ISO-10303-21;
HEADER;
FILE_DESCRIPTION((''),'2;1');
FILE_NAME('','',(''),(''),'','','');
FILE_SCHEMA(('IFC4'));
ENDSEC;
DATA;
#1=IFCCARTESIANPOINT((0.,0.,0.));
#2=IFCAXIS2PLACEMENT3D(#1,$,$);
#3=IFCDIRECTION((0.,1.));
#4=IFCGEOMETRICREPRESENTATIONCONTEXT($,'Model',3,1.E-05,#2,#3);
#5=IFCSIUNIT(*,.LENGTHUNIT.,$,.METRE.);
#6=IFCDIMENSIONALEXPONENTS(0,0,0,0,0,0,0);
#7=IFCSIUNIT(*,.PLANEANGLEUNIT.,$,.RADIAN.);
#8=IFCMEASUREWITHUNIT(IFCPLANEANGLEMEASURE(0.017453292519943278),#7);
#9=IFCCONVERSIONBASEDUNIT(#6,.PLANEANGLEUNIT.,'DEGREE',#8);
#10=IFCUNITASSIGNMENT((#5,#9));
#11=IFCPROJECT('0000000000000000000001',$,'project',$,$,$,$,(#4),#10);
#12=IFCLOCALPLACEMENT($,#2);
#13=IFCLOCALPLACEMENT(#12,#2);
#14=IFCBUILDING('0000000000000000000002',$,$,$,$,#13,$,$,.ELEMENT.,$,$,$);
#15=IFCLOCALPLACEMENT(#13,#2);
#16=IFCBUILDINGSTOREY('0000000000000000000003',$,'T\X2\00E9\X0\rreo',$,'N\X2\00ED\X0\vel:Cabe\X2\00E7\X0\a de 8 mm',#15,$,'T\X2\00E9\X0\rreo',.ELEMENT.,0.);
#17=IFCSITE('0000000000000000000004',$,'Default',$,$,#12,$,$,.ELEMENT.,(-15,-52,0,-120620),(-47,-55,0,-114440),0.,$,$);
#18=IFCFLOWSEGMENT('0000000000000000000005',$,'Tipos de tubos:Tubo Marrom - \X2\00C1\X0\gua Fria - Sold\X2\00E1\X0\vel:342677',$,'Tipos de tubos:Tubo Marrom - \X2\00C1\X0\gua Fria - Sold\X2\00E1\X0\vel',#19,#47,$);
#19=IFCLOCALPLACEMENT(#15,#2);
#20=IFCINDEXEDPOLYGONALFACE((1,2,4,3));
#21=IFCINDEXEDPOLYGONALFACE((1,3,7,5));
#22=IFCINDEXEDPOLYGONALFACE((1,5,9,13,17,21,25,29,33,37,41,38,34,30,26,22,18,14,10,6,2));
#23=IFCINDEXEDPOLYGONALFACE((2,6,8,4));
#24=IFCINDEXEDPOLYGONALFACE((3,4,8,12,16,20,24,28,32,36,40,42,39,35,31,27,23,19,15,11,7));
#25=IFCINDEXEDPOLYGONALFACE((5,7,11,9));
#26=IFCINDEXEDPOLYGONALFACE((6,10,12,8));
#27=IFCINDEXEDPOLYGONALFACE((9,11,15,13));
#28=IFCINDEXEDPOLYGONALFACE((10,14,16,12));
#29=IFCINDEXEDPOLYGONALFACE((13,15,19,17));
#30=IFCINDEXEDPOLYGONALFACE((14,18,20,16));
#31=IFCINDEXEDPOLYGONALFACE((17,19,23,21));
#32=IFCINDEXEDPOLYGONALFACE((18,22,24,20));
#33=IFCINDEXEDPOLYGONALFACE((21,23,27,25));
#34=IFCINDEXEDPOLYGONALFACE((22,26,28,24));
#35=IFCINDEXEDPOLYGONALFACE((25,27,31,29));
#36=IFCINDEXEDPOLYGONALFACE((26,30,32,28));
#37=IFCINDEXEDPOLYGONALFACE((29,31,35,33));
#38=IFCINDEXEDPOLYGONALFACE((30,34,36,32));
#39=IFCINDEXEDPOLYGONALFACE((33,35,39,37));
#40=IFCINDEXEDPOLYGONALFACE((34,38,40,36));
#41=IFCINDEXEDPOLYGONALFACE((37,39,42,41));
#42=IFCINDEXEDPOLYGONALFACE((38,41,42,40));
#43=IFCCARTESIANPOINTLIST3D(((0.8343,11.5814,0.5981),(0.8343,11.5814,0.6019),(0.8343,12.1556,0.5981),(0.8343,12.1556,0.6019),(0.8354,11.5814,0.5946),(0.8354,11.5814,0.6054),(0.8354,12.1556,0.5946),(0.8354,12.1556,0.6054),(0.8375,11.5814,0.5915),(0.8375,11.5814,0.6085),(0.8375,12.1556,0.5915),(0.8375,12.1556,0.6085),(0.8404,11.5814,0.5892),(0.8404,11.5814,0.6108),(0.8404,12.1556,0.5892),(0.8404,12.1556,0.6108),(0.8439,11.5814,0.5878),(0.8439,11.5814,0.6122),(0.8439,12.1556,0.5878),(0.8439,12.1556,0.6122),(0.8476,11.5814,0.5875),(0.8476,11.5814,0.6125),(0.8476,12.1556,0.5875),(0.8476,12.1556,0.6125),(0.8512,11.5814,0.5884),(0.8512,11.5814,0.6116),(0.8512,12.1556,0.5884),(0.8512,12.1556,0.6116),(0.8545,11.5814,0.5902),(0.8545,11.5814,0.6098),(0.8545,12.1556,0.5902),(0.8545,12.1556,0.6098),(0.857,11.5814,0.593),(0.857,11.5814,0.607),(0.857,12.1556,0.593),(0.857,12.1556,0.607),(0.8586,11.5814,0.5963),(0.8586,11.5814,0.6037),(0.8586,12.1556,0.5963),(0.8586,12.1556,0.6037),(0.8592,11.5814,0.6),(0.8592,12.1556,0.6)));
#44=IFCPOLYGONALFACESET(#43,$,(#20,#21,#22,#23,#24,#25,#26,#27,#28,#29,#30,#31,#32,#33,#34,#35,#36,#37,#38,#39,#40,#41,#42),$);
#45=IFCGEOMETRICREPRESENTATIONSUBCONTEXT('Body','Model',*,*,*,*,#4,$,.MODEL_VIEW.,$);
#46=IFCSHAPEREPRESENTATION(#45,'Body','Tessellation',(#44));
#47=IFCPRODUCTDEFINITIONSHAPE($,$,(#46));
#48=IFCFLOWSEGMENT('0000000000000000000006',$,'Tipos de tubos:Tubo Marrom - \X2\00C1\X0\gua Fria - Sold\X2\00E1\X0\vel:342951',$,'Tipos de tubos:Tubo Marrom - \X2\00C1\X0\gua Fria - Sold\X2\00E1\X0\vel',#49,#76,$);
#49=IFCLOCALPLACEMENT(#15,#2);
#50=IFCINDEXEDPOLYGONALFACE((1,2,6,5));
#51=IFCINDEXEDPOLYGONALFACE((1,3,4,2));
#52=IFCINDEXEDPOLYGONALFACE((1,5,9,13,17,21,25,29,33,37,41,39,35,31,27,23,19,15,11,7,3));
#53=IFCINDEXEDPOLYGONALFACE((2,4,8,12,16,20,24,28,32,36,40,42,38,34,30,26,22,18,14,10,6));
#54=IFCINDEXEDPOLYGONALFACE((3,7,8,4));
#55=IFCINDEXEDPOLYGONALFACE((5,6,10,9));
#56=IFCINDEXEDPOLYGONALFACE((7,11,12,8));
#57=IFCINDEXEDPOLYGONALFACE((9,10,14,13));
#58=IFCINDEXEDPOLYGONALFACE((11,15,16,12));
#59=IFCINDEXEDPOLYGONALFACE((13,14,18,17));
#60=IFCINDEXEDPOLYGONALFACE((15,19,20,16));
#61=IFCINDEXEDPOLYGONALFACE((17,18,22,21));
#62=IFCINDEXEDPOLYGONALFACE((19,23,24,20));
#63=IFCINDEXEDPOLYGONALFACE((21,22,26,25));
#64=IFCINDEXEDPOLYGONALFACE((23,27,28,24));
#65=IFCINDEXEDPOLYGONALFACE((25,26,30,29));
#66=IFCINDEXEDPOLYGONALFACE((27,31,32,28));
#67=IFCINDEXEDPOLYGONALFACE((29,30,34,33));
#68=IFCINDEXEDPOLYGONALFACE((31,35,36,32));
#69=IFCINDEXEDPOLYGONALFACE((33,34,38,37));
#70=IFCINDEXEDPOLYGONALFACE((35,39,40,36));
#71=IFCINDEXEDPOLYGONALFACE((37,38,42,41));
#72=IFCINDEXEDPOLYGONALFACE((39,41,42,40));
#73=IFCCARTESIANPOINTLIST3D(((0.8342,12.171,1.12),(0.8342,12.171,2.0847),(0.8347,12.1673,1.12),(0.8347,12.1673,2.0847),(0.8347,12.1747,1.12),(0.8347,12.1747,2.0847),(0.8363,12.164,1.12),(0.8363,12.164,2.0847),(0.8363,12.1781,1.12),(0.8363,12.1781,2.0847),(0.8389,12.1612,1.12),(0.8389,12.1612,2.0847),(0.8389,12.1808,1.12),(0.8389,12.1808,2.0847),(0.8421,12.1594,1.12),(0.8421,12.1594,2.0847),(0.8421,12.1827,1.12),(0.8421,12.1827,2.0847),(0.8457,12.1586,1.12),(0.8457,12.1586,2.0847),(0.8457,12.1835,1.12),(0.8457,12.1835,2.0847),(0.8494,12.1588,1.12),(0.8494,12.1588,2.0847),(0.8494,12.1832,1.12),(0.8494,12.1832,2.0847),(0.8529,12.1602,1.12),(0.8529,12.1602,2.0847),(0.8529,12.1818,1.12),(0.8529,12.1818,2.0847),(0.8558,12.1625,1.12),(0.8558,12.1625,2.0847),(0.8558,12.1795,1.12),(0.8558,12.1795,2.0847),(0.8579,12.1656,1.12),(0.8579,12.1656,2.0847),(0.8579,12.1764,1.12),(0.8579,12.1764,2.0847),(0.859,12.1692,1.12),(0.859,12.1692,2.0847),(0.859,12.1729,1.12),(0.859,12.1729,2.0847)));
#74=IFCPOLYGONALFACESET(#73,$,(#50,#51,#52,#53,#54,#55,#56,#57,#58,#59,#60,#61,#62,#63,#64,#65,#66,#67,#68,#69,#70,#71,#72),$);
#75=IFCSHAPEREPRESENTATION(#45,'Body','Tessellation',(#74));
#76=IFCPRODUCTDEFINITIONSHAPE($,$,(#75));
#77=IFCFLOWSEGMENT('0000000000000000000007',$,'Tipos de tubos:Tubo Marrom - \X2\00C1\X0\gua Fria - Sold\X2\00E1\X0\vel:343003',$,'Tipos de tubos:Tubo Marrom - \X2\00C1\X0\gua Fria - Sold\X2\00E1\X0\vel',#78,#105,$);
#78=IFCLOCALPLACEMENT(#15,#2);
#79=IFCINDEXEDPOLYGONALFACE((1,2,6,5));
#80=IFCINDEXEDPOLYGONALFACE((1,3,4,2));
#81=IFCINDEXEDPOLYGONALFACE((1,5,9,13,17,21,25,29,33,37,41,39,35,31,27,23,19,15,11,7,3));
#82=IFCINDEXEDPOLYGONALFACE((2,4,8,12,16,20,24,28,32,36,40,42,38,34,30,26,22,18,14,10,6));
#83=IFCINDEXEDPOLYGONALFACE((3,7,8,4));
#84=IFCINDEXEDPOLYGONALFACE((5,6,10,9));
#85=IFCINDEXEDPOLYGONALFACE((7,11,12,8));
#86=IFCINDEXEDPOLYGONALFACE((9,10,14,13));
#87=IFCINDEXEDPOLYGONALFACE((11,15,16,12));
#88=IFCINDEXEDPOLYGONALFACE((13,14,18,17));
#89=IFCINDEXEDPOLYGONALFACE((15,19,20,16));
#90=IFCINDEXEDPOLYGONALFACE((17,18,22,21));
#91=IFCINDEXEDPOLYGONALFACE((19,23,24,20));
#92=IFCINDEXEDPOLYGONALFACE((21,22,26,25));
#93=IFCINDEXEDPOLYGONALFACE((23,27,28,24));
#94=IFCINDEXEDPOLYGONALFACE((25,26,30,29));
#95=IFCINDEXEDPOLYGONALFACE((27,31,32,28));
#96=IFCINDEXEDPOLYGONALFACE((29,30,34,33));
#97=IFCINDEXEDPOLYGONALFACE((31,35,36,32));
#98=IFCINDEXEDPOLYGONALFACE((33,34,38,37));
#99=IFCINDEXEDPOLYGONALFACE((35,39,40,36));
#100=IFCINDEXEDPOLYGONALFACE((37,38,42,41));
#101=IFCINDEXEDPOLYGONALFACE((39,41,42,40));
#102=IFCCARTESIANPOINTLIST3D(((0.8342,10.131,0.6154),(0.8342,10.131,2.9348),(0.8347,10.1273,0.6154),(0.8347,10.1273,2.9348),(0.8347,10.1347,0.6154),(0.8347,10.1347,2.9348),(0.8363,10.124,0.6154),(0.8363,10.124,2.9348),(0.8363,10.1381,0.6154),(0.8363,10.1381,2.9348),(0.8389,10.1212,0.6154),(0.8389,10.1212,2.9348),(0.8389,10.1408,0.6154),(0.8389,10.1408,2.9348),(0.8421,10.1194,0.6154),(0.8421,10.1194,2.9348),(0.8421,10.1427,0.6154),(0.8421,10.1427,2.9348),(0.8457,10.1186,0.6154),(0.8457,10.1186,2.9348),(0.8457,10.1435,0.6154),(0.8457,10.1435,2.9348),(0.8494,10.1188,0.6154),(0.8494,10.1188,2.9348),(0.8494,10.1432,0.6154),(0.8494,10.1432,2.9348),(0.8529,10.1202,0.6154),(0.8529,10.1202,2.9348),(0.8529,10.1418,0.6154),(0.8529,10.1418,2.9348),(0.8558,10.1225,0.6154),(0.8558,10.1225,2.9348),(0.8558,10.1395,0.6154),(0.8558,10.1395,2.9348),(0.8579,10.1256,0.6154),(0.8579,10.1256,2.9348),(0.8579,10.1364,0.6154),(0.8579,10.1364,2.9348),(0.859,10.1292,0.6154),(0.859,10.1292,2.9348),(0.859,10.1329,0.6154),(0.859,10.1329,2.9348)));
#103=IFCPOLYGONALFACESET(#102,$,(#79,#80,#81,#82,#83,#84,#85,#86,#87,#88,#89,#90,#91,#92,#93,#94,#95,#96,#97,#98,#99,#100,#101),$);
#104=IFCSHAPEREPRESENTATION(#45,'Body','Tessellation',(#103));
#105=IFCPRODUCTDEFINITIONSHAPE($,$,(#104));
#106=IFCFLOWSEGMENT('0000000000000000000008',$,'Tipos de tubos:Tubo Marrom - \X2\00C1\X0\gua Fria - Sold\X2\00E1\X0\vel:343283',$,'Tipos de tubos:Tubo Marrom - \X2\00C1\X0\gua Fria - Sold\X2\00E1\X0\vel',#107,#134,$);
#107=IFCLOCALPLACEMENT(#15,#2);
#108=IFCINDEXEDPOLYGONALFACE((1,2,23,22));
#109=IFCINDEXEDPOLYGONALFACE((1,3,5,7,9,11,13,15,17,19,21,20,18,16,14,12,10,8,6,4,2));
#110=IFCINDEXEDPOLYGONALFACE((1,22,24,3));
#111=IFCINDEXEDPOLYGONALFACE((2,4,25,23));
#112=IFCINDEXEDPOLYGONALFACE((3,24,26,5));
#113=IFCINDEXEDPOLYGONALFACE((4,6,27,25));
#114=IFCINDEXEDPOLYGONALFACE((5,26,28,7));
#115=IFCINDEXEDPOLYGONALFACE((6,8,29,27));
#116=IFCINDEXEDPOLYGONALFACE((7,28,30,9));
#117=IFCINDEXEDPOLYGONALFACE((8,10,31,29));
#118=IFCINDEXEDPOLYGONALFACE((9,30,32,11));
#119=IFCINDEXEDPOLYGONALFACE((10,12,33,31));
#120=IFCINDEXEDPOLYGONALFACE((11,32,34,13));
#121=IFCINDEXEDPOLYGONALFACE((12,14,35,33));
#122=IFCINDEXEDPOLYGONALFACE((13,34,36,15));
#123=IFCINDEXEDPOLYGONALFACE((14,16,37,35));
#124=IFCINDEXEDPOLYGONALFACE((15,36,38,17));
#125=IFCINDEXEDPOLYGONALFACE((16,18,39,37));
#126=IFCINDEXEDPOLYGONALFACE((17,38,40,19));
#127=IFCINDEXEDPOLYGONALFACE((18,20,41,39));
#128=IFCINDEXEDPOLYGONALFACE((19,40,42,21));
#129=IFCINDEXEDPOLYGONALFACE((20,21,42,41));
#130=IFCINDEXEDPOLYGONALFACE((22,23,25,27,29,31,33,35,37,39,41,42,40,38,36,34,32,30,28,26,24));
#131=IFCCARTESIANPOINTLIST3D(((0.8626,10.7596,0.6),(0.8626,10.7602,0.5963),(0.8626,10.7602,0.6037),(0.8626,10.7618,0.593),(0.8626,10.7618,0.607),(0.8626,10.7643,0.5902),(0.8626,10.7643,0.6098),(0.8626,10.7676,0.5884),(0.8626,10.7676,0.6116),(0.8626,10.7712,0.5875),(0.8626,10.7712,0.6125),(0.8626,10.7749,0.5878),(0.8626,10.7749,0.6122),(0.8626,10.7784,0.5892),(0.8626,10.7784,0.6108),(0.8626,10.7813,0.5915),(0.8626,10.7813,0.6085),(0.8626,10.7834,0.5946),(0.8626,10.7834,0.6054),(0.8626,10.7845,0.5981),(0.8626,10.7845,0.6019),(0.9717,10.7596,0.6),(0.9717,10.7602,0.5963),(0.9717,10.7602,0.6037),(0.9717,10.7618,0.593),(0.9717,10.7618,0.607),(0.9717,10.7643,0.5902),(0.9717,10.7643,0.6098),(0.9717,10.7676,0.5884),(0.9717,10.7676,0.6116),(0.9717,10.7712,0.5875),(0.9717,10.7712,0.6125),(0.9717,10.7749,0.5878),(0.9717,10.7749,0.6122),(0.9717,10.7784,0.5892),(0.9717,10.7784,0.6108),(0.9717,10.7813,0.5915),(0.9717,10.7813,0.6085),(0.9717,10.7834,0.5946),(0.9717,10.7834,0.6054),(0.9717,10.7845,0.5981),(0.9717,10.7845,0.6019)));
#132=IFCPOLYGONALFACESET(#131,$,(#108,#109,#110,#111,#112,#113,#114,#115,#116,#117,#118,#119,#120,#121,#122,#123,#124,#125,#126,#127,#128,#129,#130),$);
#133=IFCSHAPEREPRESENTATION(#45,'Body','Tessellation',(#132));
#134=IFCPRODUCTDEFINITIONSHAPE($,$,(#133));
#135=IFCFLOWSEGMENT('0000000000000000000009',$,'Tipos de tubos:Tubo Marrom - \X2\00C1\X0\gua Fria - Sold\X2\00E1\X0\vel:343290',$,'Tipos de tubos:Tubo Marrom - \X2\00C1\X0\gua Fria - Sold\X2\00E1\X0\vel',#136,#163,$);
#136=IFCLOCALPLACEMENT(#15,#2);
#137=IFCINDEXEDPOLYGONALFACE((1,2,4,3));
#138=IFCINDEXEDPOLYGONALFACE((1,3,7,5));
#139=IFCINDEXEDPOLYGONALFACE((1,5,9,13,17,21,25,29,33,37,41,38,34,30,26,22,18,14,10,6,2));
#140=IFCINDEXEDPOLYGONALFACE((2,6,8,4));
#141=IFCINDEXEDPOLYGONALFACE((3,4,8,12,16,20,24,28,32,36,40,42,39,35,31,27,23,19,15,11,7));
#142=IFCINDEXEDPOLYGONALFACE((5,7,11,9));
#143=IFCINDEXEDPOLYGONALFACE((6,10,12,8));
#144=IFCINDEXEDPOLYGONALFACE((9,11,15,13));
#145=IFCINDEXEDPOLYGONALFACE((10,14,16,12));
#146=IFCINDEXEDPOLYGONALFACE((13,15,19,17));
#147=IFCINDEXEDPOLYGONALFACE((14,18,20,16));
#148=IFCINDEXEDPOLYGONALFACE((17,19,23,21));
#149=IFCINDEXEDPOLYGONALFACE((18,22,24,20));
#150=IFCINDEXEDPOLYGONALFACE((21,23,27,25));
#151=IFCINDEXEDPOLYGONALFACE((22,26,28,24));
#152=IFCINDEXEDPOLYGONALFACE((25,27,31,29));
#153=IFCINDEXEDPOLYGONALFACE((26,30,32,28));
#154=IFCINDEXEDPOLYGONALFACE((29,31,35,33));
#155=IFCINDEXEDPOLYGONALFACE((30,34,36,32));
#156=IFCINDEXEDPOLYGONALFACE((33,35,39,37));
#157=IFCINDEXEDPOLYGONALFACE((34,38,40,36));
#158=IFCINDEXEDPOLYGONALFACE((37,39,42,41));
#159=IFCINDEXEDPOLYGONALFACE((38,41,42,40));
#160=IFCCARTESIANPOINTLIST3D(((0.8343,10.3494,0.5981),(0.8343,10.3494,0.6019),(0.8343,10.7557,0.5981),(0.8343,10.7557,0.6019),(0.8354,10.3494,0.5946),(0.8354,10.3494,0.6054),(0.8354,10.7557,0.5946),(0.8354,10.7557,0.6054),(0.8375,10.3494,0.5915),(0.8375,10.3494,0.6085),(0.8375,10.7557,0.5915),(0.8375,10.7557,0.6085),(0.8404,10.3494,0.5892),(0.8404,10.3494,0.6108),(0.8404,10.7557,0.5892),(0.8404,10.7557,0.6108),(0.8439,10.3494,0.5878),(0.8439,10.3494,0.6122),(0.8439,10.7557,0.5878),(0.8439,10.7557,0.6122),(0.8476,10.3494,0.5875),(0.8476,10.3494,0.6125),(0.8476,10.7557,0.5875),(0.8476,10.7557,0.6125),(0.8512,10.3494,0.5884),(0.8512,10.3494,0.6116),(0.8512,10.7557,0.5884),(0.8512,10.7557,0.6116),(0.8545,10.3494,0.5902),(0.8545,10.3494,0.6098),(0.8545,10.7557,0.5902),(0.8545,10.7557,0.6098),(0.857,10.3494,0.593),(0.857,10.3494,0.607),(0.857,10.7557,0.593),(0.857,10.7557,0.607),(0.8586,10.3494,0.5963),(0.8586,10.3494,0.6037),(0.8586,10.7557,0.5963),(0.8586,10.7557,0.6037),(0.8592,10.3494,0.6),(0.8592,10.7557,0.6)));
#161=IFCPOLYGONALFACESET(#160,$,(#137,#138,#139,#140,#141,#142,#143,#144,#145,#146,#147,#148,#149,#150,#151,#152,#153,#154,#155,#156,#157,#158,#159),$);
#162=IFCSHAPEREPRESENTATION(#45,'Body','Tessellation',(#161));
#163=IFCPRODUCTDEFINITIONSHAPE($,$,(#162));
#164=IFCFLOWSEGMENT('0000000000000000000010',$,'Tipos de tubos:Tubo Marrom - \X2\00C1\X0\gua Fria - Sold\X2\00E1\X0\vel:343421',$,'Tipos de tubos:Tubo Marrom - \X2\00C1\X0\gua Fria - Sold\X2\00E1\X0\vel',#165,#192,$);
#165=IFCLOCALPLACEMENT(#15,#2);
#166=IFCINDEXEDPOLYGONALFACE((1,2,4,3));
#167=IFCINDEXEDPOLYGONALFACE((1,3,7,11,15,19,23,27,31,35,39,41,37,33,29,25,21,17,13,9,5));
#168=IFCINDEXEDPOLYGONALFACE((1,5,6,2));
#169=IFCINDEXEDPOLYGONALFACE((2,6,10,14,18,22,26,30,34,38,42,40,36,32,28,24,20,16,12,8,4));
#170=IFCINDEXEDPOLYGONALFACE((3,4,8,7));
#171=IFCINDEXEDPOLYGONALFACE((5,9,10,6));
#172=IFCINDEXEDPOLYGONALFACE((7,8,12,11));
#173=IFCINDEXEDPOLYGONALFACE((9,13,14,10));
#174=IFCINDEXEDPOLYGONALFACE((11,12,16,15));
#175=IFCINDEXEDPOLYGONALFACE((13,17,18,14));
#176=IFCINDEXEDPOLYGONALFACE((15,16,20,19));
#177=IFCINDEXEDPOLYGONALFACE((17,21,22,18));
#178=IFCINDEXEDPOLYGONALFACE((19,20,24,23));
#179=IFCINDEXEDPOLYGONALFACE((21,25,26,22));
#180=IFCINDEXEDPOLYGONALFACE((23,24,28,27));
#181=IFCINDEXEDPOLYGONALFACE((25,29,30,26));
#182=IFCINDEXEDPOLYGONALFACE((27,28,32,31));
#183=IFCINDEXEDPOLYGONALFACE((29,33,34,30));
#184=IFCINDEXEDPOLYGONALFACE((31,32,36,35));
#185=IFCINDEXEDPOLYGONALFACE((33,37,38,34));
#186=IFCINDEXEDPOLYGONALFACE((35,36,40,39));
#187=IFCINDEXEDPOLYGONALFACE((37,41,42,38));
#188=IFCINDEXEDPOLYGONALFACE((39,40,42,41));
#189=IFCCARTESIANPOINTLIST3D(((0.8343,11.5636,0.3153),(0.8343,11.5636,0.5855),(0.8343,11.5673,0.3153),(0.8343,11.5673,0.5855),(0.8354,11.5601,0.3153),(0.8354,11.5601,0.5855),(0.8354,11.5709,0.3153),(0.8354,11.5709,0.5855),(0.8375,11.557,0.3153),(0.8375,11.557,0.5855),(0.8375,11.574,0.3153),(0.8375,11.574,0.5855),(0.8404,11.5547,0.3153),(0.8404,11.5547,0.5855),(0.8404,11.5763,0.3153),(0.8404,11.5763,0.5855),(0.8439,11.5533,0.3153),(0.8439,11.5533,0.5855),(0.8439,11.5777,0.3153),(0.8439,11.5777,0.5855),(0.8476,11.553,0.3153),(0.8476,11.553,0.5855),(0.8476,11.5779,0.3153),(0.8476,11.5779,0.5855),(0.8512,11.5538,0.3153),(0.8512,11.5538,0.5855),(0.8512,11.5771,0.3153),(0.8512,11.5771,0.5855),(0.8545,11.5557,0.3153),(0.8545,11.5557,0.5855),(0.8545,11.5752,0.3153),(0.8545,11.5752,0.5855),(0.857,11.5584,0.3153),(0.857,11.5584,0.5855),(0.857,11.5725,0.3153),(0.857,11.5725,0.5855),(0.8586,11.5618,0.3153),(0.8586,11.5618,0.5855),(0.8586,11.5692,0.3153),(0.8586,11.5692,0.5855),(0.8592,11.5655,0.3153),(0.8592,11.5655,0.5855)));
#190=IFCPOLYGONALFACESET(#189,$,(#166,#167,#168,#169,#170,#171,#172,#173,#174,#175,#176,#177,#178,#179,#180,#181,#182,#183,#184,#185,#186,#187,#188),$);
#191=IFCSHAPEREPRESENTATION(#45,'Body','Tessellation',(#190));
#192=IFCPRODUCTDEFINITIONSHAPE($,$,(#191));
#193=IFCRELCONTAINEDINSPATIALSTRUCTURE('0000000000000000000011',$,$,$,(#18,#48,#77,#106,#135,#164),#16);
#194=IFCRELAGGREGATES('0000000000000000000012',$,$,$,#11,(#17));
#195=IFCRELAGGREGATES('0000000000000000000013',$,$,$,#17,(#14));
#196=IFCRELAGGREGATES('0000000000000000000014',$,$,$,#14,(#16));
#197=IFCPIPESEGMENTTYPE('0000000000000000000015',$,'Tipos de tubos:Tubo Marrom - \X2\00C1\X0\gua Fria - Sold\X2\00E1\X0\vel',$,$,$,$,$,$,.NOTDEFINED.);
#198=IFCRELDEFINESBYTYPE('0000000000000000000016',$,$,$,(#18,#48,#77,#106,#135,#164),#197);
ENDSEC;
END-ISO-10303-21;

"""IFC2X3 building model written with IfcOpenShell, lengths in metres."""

from ifc_helpers import new_model, entity, si_unit, converted_unit, direction, frame, frame_2d, origin, origin_2d_with_axis, place, context, subcontext, project, spatial, circle, extrude, type_object, element, save


model = new_model("IFC2X3")

# Units and contexts
model_context = context("Model", 3, precision=1e-05, world=origin(), true_north=direction((0.0, 1.0)))
body_context = subcontext(model_context, "Body", "Model", "MODEL_VIEW")
ifc_project = project(units=[si_unit("LENGTHUNIT", "METRE"), converted_unit("PLANEANGLEUNIT", "DEGREE", entity("IfcPlaneAngleMeasure", 0.017453292519943278), si_unit("PLANEANGLEUNIT", "RADIAN"), dimensions=[0, 0, 0, 0, 0, 0, 0])], contexts=[model_context])

# Site, building, storey
site_placement = place(None, origin())
site = spatial("IfcSite", under=ifc_project, at=site_placement, Name="Default", CompositionType="ELEMENT", RefLatitude=(-15, -52, 0, -120620), RefLongitude=(-47, -55, 0, -114440), RefElevation=0.0)
building_placement = place(site_placement, origin())
building = spatial("IfcBuilding", under=site, at=building_placement, CompositionType="ELEMENT")
storey_placement = place(building_placement, origin())
storey = spatial("IfcBuildingStorey", under=building, at=storey_placement, Name="Térreo", ObjectType="Nível:Cabeça de 8 mm", LongName="Térreo", CompositionType="ELEMENT", Elevation=0.0)

# Flow segments
pipe_segment_type = type_object("IfcPipeSegmentType", Name="Tipos de tubos:Tubo Marrom - Água Fria - Soldável", PredefinedType="NOTDEFINED")
flow_segment_1_placement = place(storey_placement, origin())
element("IfcFlowSegment", 1, at=flow_segment_1_placement, inside=storey, type_object=pipe_segment_type, Name="Tipos de tubos:Tubo Marrom - Água Fria - Soldável:342677", ObjectType="Tipos de tubos:Tubo Marrom - Água Fria - Soldável", context=body_context, shape_type="SweptSolid", body=[
    extrude(circle(Radius=0.0125, at=origin_2d_with_axis()), frame((0.8467, 11.5814, 0.6), z_axis=(0.0, 1.0, 0.0), x_axis=(1.0, 0.0, 0.0)), (0.0, 0.0, 1.0), 0.5742),
])
flow_segment_2_placement = place(storey_placement, origin())
element("IfcFlowSegment", 2, at=flow_segment_2_placement, inside=storey, type_object=pipe_segment_type, Name="Tipos de tubos:Tubo Marrom - Água Fria - Soldável:342951", ObjectType="Tipos de tubos:Tubo Marrom - Água Fria - Soldável", context=body_context, shape_type="SweptSolid", body=[
    extrude(circle(Radius=0.0125, at=frame_2d((0.0, 0.0), x_axis=(1.0, 0.0))), frame((0.8467, 12.171, 1.12), z_axis=(0.0, 0.0, 1.0), x_axis=(-1.0, 0.0, 0.0)), (0.0, 0.0, 1.0), 0.9647),
])
flow_segment_3_placement = place(storey_placement, origin())
element("IfcFlowSegment", 3, at=flow_segment_3_placement, inside=storey, type_object=pipe_segment_type, Name="Tipos de tubos:Tubo Marrom - Água Fria - Soldável:343003", ObjectType="Tipos de tubos:Tubo Marrom - Água Fria - Soldável", context=body_context, shape_type="SweptSolid", body=[
    extrude(circle(Radius=0.0125, at=frame_2d((0.0, 0.0), x_axis=(1.0, 0.0))), frame((0.8467, 10.131, 0.6154), z_axis=(0.0, 0.0, 1.0), x_axis=(-1.0, 0.0, 0.0)), (0.0, 0.0, 1.0), 2.3194),
])
flow_segment_4_placement = place(storey_placement, origin())
element("IfcFlowSegment", 4, at=flow_segment_4_placement, inside=storey, type_object=pipe_segment_type, Name="Tipos de tubos:Tubo Marrom - Água Fria - Soldável:343283", ObjectType="Tipos de tubos:Tubo Marrom - Água Fria - Soldável", context=body_context, shape_type="SweptSolid", body=[
    extrude(circle(Radius=0.0125, at=origin_2d_with_axis()), frame((0.8626, 10.7721, 0.6), z_axis=(1.0, 0.0, 0.0), x_axis=(0.0, -1.0, 0.0)), (0.0, 0.0, 1.0), 0.1091),
])
flow_segment_5_placement = place(storey_placement, origin())
element("IfcFlowSegment", 5, at=flow_segment_5_placement, inside=storey, type_object=pipe_segment_type, Name="Tipos de tubos:Tubo Marrom - Água Fria - Soldável:343290", ObjectType="Tipos de tubos:Tubo Marrom - Água Fria - Soldável", context=body_context, shape_type="SweptSolid", body=[
    extrude(circle(Radius=0.0125, at=origin_2d_with_axis()), frame((0.8467, 10.3494, 0.6), z_axis=(0.0, 1.0, 0.0), x_axis=(1.0, 0.0, 0.0)), (0.0, 0.0, 1.0), 0.4063),
])
flow_segment_6_placement = place(storey_placement, origin())
element("IfcFlowSegment", 6, at=flow_segment_6_placement, inside=storey, type_object=pipe_segment_type, Name="Tipos de tubos:Tubo Marrom - Água Fria - Soldável:343421", ObjectType="Tipos de tubos:Tubo Marrom - Água Fria - Soldável", context=body_context, shape_type="SweptSolid", body=[
    extrude(circle(Radius=0.0125, at=frame_2d((0.0, 0.0), x_axis=(1.0, 0.0))), frame((0.8467, 11.5655, 0.3153)), (0.0, 0.0, 1.0), 0.2702),
])

save(model, "model.ifc")
